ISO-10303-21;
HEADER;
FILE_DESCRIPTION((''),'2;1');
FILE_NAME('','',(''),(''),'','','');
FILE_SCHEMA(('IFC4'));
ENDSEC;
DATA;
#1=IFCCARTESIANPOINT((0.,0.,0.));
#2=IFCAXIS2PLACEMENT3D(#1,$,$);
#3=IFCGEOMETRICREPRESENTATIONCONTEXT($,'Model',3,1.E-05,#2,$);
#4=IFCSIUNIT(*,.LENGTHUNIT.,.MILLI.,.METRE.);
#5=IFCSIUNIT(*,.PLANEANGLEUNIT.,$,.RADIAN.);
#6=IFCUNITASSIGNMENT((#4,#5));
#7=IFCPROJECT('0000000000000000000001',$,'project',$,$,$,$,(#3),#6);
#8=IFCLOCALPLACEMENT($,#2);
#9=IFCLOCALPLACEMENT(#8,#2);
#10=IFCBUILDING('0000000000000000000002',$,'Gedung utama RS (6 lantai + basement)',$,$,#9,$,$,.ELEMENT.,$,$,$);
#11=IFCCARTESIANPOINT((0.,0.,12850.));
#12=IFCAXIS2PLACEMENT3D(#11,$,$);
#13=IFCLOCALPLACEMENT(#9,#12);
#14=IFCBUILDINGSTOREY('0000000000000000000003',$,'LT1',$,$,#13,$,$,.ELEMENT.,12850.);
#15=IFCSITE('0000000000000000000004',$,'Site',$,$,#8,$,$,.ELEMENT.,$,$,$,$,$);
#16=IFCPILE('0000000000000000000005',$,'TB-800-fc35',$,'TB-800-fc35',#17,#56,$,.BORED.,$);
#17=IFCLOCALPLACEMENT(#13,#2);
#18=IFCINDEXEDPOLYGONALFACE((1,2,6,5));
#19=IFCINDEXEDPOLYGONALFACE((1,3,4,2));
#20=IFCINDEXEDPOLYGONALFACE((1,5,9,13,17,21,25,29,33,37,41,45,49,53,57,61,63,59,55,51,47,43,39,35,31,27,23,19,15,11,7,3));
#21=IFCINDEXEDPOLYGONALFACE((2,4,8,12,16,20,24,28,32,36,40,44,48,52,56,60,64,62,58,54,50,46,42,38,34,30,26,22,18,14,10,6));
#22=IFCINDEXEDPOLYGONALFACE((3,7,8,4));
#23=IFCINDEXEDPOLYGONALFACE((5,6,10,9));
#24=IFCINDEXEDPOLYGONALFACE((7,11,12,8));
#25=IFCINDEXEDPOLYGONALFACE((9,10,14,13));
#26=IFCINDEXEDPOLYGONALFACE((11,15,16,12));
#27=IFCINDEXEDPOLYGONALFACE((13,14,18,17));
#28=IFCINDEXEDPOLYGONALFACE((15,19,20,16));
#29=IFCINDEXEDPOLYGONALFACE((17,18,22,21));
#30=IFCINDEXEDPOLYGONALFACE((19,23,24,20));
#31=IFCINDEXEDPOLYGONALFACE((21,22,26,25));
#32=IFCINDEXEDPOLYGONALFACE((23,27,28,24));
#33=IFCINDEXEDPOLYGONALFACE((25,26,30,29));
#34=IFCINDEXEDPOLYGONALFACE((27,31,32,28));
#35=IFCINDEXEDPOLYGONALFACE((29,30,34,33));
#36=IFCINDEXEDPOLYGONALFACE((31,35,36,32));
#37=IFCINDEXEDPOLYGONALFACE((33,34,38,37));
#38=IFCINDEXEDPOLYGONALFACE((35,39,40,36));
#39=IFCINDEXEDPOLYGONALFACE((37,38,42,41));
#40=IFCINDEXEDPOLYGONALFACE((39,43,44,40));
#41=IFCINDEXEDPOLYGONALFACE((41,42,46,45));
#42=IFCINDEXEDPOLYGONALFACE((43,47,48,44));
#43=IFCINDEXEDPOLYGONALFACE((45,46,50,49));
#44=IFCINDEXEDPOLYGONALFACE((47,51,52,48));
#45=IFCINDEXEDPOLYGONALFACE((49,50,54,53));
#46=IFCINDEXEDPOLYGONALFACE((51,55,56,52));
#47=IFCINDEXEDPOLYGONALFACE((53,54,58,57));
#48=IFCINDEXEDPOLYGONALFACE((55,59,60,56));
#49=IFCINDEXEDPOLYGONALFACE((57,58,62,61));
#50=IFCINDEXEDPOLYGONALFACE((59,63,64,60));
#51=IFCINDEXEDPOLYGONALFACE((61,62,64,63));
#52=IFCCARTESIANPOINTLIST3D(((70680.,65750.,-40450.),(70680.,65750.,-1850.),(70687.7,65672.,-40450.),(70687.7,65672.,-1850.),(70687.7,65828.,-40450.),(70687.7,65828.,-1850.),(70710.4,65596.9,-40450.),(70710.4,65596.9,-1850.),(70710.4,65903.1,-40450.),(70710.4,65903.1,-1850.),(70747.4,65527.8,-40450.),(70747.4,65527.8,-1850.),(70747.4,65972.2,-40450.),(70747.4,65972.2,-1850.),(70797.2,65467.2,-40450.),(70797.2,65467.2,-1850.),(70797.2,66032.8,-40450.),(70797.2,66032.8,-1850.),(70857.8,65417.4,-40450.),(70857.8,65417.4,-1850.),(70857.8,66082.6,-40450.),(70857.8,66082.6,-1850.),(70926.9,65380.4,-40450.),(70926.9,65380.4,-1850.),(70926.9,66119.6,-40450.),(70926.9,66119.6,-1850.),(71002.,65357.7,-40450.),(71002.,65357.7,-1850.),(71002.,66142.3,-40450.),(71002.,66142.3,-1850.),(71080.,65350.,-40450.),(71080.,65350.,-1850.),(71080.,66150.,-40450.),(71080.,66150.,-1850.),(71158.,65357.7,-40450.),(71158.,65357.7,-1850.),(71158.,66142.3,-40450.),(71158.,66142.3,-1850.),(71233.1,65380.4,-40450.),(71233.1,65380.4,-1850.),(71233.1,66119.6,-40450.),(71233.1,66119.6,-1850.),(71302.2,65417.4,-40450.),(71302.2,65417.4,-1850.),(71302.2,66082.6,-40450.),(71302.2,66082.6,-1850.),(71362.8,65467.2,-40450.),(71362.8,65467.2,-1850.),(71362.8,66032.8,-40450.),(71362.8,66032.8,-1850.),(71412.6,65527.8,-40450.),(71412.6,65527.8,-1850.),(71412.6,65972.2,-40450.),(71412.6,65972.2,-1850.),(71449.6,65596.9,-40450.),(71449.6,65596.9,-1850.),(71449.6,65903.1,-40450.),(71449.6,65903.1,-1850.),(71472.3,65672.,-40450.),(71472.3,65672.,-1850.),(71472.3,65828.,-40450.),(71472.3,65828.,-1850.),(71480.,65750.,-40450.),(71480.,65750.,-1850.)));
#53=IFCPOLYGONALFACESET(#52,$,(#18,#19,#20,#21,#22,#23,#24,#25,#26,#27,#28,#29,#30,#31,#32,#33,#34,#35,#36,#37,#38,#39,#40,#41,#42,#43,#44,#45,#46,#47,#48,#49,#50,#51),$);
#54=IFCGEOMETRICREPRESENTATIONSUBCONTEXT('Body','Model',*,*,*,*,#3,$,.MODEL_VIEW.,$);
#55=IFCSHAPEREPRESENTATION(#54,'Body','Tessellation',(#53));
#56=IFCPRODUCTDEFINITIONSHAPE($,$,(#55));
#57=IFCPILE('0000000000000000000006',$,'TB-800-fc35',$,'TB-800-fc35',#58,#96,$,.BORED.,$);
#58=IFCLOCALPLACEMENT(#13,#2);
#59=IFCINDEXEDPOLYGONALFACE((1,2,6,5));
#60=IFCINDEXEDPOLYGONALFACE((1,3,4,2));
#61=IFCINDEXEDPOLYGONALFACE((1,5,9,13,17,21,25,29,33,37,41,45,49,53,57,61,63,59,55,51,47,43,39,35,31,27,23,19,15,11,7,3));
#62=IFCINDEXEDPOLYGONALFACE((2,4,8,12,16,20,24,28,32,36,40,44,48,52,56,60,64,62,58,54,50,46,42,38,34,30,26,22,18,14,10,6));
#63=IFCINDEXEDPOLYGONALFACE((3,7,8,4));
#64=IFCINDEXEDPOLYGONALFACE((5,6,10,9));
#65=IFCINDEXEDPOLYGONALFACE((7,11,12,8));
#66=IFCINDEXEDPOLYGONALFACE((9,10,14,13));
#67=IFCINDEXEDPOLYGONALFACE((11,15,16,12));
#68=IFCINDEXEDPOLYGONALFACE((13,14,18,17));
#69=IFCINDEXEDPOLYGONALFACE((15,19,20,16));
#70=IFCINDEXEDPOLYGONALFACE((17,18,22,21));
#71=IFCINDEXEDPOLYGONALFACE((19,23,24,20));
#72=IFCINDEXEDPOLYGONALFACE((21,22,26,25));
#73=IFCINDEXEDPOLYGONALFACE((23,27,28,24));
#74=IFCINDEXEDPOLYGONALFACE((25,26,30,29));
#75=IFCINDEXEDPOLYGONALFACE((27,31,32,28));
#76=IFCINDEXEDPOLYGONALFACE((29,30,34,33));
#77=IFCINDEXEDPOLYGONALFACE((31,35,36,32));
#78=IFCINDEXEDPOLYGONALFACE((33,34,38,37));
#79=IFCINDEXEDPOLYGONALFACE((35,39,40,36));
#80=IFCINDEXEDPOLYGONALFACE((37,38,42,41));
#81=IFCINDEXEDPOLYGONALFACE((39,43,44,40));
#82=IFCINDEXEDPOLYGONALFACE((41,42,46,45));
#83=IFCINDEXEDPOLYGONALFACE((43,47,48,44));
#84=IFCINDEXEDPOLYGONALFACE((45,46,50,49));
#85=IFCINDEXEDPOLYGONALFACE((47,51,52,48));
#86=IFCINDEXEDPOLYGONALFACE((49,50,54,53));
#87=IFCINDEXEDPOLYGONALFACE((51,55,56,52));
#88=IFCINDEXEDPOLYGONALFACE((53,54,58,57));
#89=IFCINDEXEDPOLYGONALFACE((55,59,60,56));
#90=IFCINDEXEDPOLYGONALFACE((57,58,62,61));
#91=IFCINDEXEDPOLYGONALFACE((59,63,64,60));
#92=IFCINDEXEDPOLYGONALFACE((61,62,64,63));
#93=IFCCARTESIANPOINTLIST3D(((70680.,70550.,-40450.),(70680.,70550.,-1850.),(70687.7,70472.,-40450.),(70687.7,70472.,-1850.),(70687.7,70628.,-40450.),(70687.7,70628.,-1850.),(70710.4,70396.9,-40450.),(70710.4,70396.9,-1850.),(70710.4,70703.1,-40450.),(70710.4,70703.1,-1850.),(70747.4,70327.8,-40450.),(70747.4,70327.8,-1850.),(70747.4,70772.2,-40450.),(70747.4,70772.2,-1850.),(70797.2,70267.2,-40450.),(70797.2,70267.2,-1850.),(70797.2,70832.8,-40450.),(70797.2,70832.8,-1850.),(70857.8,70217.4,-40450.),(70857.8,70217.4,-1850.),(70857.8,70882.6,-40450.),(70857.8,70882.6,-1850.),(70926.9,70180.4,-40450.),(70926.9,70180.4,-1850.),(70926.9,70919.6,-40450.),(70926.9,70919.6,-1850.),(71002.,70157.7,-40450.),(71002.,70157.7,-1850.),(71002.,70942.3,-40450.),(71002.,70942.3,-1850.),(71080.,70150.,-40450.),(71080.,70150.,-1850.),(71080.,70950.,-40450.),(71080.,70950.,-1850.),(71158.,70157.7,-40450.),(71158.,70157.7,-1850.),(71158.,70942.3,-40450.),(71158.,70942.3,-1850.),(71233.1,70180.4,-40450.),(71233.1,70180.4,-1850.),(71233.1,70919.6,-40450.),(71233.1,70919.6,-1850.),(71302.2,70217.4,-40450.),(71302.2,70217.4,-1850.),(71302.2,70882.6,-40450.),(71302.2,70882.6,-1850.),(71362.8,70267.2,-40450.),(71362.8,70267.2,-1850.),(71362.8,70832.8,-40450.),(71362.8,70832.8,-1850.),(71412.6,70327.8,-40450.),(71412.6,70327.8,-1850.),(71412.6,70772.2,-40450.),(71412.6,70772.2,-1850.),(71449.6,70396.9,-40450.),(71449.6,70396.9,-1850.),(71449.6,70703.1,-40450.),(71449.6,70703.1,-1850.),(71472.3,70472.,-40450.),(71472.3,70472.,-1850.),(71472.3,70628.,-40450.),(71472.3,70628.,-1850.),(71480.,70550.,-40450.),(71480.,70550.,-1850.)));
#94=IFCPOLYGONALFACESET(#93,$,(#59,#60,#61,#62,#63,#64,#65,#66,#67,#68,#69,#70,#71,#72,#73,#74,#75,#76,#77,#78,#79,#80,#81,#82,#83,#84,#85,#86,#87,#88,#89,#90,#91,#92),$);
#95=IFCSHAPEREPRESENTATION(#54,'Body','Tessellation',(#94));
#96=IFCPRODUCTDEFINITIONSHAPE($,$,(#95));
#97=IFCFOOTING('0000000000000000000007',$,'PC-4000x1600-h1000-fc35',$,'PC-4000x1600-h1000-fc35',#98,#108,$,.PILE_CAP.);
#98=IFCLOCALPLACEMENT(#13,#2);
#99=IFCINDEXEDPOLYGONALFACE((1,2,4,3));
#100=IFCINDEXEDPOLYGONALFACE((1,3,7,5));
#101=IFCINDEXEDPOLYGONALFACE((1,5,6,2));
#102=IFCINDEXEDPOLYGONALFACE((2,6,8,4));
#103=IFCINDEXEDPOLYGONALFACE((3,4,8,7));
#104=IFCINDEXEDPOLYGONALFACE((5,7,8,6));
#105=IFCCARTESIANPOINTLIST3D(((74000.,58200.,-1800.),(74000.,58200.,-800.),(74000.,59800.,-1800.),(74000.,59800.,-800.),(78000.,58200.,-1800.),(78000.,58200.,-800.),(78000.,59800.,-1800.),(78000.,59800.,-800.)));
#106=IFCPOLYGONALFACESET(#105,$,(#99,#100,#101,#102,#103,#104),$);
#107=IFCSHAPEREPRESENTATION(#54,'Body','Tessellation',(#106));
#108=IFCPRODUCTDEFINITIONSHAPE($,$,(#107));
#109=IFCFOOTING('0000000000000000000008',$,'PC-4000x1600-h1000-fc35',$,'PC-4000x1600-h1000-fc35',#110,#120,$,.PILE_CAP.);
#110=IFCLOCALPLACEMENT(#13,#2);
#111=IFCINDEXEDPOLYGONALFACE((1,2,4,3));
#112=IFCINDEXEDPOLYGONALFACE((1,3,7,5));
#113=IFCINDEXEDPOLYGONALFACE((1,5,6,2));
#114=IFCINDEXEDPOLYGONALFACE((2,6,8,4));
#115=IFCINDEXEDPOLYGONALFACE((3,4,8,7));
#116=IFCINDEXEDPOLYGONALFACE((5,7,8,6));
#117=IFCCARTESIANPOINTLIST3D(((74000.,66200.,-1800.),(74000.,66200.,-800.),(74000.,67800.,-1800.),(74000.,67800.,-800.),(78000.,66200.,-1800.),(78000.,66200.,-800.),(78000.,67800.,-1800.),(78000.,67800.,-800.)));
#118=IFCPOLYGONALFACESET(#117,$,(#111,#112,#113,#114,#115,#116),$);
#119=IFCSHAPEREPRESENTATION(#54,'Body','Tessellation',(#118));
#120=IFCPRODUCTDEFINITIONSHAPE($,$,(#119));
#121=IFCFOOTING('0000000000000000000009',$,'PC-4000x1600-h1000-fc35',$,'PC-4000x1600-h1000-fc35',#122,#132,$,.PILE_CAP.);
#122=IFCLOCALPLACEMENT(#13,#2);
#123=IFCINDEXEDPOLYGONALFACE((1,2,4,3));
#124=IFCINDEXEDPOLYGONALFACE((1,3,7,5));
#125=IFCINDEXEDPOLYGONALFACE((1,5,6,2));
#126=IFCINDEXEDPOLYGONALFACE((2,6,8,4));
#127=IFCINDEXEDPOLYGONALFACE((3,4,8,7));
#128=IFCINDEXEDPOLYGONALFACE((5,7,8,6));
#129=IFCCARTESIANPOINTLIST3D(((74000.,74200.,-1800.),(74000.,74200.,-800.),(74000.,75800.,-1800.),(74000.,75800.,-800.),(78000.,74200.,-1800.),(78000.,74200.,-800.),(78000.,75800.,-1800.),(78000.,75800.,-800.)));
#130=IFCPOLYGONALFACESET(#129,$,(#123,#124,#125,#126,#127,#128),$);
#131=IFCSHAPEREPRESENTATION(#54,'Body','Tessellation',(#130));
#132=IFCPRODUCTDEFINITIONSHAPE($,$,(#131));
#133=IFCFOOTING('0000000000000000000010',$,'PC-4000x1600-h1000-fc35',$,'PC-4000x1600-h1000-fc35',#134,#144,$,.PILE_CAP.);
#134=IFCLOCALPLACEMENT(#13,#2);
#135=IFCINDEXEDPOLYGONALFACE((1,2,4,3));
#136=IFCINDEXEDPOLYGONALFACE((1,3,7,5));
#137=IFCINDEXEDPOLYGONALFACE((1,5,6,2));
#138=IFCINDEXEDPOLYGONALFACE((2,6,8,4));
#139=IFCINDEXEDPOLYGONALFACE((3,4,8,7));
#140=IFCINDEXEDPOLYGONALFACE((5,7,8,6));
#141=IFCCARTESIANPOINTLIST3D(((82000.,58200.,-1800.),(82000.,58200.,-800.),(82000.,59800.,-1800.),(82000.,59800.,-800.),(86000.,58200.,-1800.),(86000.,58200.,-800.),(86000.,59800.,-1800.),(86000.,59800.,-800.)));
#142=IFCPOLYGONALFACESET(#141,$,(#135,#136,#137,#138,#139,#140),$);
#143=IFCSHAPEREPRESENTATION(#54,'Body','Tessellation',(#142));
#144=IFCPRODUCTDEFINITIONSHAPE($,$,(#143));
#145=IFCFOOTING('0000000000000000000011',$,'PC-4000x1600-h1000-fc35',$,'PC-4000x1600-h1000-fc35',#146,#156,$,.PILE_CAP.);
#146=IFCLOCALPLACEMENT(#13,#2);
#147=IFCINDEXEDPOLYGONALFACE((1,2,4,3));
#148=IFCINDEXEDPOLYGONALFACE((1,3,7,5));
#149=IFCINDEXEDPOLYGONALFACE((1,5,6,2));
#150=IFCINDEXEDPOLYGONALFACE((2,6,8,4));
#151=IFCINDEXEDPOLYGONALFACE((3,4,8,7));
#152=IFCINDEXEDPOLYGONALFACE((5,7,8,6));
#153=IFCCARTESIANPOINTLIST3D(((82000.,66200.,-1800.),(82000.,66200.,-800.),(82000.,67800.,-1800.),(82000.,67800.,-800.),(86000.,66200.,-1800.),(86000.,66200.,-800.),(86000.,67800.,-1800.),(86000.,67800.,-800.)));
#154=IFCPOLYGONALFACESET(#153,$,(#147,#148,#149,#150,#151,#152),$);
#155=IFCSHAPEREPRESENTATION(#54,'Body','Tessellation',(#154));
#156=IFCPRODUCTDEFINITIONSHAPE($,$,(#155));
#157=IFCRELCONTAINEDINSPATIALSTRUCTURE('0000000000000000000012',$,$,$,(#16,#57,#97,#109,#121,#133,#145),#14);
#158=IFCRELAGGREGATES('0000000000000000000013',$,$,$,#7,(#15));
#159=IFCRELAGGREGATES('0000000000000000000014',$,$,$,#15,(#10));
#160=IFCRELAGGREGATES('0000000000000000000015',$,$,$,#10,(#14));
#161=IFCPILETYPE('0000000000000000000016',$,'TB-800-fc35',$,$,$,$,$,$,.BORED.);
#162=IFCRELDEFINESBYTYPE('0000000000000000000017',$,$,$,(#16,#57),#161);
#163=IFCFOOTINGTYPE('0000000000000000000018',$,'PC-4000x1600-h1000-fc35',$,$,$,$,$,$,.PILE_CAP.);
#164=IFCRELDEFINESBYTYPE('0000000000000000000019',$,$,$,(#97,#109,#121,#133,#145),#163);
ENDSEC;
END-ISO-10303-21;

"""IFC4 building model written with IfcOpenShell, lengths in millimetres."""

from ifc_helpers import new_model, si_unit, frame, origin, origin_2d, place, context, subcontext, project, spatial, rectangle, circle, extrude, material_profile, profile_set, profile_usage, type_object, element, save


model = new_model("IFC4")

# Units and contexts
model_context = context("Model", 3, precision=1e-05, world=origin())
body_context = subcontext(model_context, "Body", "Model", "MODEL_VIEW")
ifc_project = project(units=[si_unit("LENGTHUNIT", "METRE", prefix="MILLI"), si_unit("PLANEANGLEUNIT", "RADIAN")], contexts=[model_context])

# Site, building, storey
site_placement = place(None, origin())
site = spatial("IfcSite", under=ifc_project, at=site_placement, Name="Site", CompositionType="ELEMENT")
building_placement = place(site_placement, origin())
building = spatial("IfcBuilding", under=site, at=building_placement, Name="Gedung utama RS (6 lantai + basement)", CompositionType="ELEMENT")
storey_placement = place(building_placement, frame((0.0, 0.0, 12850.0)))
storey = spatial("IfcBuildingStorey", under=building, at=storey_placement, Name="LT1", CompositionType="ELEMENT", Elevation=12850.0)

# Piles
ifc_material_profile_1 = material_profile(None, circle(Radius=400.0, at=origin_2d()), Name="TB-800-fc35")
ifc_profile_set_1 = profile_set([ifc_material_profile_1], Name="TB-800-fc35")
ifc_profile_usage_1 = profile_usage(ifc_profile_set_1, cardinal=5)
pile_type = type_object("IfcPileType", Name="TB-800-fc35", PredefinedType="BORED")
for number, where, z_axis, x_axis, name in (
    (1, (71080.0, 65750.0, -40450.0), (0.0, 0.0, 1.0), (1.0, 0.0, 0.0), "TB-800-fc35"),
    (2, (71080.0, 70550.0, -40450.0), (0.0, 0.0, 1.0), (1.0, 0.0, 0.0), "TB-800-fc35"),
):
    element("IfcPile", number, at=place(storey_placement, frame(where, z_axis=z_axis, x_axis=x_axis)), inside=storey, type_object=pile_type, material=ifc_profile_usage_1, Name=name, ObjectType="TB-800-fc35", PredefinedType="BORED", context=body_context, shape_type="SweptSolid", body=[
        extrude(circle(Radius=400.0, at=origin_2d()), origin(), (0.0, 0.0, 1.0), 38600.0),
    ])

# Footings
ifc_material_profile_2 = material_profile(None, rectangle(XDim=4000.0, YDim=1600.0, at=origin_2d()), Name="PC-4000x1600-h1000-fc35")
ifc_profile_set_2 = profile_set([ifc_material_profile_2], Name="PC-4000x1600-h1000-fc35")
ifc_profile_usage_2 = profile_usage(ifc_profile_set_2, cardinal=5)
footing_type = type_object("IfcFootingType", Name="PC-4000x1600-h1000-fc35", PredefinedType="PILE_CAP")
for number, where, z_axis, x_axis, name in (
    (3, (76000.0, 59000.0, -1800.0), (0.0, 0.0, 1.0), (1.0, 0.0, 0.0), "PC-4000x1600-h1000-fc35"),
    (4, (76000.0, 67000.0, -1800.0), (0.0, 0.0, 1.0), (1.0, 0.0, 0.0), "PC-4000x1600-h1000-fc35"),
    (5, (76000.0, 75000.0, -1800.0), (0.0, 0.0, 1.0), (1.0, 0.0, 0.0), "PC-4000x1600-h1000-fc35"),
    (6, (84000.0, 59000.0, -1800.0), (0.0, 0.0, 1.0), (1.0, 0.0, 0.0), "PC-4000x1600-h1000-fc35"),
    (7, (84000.0, 67000.0, -1800.0), (0.0, 0.0, 1.0), (1.0, 0.0, 0.0), "PC-4000x1600-h1000-fc35"),
):
    element("IfcFooting", number, at=place(storey_placement, frame(where, z_axis=z_axis, x_axis=x_axis)), inside=storey, type_object=footing_type, material=ifc_profile_usage_2, Name=name, ObjectType="PC-4000x1600-h1000-fc35", PredefinedType="PILE_CAP", context=body_context, shape_type="SweptSolid", body=[
        extrude(rectangle(XDim=4000.0, YDim=1600.0, at=origin_2d()), origin(), (0.0, 0.0, 1.0), 1000.0),
    ])

save(model, "model.ifc")
